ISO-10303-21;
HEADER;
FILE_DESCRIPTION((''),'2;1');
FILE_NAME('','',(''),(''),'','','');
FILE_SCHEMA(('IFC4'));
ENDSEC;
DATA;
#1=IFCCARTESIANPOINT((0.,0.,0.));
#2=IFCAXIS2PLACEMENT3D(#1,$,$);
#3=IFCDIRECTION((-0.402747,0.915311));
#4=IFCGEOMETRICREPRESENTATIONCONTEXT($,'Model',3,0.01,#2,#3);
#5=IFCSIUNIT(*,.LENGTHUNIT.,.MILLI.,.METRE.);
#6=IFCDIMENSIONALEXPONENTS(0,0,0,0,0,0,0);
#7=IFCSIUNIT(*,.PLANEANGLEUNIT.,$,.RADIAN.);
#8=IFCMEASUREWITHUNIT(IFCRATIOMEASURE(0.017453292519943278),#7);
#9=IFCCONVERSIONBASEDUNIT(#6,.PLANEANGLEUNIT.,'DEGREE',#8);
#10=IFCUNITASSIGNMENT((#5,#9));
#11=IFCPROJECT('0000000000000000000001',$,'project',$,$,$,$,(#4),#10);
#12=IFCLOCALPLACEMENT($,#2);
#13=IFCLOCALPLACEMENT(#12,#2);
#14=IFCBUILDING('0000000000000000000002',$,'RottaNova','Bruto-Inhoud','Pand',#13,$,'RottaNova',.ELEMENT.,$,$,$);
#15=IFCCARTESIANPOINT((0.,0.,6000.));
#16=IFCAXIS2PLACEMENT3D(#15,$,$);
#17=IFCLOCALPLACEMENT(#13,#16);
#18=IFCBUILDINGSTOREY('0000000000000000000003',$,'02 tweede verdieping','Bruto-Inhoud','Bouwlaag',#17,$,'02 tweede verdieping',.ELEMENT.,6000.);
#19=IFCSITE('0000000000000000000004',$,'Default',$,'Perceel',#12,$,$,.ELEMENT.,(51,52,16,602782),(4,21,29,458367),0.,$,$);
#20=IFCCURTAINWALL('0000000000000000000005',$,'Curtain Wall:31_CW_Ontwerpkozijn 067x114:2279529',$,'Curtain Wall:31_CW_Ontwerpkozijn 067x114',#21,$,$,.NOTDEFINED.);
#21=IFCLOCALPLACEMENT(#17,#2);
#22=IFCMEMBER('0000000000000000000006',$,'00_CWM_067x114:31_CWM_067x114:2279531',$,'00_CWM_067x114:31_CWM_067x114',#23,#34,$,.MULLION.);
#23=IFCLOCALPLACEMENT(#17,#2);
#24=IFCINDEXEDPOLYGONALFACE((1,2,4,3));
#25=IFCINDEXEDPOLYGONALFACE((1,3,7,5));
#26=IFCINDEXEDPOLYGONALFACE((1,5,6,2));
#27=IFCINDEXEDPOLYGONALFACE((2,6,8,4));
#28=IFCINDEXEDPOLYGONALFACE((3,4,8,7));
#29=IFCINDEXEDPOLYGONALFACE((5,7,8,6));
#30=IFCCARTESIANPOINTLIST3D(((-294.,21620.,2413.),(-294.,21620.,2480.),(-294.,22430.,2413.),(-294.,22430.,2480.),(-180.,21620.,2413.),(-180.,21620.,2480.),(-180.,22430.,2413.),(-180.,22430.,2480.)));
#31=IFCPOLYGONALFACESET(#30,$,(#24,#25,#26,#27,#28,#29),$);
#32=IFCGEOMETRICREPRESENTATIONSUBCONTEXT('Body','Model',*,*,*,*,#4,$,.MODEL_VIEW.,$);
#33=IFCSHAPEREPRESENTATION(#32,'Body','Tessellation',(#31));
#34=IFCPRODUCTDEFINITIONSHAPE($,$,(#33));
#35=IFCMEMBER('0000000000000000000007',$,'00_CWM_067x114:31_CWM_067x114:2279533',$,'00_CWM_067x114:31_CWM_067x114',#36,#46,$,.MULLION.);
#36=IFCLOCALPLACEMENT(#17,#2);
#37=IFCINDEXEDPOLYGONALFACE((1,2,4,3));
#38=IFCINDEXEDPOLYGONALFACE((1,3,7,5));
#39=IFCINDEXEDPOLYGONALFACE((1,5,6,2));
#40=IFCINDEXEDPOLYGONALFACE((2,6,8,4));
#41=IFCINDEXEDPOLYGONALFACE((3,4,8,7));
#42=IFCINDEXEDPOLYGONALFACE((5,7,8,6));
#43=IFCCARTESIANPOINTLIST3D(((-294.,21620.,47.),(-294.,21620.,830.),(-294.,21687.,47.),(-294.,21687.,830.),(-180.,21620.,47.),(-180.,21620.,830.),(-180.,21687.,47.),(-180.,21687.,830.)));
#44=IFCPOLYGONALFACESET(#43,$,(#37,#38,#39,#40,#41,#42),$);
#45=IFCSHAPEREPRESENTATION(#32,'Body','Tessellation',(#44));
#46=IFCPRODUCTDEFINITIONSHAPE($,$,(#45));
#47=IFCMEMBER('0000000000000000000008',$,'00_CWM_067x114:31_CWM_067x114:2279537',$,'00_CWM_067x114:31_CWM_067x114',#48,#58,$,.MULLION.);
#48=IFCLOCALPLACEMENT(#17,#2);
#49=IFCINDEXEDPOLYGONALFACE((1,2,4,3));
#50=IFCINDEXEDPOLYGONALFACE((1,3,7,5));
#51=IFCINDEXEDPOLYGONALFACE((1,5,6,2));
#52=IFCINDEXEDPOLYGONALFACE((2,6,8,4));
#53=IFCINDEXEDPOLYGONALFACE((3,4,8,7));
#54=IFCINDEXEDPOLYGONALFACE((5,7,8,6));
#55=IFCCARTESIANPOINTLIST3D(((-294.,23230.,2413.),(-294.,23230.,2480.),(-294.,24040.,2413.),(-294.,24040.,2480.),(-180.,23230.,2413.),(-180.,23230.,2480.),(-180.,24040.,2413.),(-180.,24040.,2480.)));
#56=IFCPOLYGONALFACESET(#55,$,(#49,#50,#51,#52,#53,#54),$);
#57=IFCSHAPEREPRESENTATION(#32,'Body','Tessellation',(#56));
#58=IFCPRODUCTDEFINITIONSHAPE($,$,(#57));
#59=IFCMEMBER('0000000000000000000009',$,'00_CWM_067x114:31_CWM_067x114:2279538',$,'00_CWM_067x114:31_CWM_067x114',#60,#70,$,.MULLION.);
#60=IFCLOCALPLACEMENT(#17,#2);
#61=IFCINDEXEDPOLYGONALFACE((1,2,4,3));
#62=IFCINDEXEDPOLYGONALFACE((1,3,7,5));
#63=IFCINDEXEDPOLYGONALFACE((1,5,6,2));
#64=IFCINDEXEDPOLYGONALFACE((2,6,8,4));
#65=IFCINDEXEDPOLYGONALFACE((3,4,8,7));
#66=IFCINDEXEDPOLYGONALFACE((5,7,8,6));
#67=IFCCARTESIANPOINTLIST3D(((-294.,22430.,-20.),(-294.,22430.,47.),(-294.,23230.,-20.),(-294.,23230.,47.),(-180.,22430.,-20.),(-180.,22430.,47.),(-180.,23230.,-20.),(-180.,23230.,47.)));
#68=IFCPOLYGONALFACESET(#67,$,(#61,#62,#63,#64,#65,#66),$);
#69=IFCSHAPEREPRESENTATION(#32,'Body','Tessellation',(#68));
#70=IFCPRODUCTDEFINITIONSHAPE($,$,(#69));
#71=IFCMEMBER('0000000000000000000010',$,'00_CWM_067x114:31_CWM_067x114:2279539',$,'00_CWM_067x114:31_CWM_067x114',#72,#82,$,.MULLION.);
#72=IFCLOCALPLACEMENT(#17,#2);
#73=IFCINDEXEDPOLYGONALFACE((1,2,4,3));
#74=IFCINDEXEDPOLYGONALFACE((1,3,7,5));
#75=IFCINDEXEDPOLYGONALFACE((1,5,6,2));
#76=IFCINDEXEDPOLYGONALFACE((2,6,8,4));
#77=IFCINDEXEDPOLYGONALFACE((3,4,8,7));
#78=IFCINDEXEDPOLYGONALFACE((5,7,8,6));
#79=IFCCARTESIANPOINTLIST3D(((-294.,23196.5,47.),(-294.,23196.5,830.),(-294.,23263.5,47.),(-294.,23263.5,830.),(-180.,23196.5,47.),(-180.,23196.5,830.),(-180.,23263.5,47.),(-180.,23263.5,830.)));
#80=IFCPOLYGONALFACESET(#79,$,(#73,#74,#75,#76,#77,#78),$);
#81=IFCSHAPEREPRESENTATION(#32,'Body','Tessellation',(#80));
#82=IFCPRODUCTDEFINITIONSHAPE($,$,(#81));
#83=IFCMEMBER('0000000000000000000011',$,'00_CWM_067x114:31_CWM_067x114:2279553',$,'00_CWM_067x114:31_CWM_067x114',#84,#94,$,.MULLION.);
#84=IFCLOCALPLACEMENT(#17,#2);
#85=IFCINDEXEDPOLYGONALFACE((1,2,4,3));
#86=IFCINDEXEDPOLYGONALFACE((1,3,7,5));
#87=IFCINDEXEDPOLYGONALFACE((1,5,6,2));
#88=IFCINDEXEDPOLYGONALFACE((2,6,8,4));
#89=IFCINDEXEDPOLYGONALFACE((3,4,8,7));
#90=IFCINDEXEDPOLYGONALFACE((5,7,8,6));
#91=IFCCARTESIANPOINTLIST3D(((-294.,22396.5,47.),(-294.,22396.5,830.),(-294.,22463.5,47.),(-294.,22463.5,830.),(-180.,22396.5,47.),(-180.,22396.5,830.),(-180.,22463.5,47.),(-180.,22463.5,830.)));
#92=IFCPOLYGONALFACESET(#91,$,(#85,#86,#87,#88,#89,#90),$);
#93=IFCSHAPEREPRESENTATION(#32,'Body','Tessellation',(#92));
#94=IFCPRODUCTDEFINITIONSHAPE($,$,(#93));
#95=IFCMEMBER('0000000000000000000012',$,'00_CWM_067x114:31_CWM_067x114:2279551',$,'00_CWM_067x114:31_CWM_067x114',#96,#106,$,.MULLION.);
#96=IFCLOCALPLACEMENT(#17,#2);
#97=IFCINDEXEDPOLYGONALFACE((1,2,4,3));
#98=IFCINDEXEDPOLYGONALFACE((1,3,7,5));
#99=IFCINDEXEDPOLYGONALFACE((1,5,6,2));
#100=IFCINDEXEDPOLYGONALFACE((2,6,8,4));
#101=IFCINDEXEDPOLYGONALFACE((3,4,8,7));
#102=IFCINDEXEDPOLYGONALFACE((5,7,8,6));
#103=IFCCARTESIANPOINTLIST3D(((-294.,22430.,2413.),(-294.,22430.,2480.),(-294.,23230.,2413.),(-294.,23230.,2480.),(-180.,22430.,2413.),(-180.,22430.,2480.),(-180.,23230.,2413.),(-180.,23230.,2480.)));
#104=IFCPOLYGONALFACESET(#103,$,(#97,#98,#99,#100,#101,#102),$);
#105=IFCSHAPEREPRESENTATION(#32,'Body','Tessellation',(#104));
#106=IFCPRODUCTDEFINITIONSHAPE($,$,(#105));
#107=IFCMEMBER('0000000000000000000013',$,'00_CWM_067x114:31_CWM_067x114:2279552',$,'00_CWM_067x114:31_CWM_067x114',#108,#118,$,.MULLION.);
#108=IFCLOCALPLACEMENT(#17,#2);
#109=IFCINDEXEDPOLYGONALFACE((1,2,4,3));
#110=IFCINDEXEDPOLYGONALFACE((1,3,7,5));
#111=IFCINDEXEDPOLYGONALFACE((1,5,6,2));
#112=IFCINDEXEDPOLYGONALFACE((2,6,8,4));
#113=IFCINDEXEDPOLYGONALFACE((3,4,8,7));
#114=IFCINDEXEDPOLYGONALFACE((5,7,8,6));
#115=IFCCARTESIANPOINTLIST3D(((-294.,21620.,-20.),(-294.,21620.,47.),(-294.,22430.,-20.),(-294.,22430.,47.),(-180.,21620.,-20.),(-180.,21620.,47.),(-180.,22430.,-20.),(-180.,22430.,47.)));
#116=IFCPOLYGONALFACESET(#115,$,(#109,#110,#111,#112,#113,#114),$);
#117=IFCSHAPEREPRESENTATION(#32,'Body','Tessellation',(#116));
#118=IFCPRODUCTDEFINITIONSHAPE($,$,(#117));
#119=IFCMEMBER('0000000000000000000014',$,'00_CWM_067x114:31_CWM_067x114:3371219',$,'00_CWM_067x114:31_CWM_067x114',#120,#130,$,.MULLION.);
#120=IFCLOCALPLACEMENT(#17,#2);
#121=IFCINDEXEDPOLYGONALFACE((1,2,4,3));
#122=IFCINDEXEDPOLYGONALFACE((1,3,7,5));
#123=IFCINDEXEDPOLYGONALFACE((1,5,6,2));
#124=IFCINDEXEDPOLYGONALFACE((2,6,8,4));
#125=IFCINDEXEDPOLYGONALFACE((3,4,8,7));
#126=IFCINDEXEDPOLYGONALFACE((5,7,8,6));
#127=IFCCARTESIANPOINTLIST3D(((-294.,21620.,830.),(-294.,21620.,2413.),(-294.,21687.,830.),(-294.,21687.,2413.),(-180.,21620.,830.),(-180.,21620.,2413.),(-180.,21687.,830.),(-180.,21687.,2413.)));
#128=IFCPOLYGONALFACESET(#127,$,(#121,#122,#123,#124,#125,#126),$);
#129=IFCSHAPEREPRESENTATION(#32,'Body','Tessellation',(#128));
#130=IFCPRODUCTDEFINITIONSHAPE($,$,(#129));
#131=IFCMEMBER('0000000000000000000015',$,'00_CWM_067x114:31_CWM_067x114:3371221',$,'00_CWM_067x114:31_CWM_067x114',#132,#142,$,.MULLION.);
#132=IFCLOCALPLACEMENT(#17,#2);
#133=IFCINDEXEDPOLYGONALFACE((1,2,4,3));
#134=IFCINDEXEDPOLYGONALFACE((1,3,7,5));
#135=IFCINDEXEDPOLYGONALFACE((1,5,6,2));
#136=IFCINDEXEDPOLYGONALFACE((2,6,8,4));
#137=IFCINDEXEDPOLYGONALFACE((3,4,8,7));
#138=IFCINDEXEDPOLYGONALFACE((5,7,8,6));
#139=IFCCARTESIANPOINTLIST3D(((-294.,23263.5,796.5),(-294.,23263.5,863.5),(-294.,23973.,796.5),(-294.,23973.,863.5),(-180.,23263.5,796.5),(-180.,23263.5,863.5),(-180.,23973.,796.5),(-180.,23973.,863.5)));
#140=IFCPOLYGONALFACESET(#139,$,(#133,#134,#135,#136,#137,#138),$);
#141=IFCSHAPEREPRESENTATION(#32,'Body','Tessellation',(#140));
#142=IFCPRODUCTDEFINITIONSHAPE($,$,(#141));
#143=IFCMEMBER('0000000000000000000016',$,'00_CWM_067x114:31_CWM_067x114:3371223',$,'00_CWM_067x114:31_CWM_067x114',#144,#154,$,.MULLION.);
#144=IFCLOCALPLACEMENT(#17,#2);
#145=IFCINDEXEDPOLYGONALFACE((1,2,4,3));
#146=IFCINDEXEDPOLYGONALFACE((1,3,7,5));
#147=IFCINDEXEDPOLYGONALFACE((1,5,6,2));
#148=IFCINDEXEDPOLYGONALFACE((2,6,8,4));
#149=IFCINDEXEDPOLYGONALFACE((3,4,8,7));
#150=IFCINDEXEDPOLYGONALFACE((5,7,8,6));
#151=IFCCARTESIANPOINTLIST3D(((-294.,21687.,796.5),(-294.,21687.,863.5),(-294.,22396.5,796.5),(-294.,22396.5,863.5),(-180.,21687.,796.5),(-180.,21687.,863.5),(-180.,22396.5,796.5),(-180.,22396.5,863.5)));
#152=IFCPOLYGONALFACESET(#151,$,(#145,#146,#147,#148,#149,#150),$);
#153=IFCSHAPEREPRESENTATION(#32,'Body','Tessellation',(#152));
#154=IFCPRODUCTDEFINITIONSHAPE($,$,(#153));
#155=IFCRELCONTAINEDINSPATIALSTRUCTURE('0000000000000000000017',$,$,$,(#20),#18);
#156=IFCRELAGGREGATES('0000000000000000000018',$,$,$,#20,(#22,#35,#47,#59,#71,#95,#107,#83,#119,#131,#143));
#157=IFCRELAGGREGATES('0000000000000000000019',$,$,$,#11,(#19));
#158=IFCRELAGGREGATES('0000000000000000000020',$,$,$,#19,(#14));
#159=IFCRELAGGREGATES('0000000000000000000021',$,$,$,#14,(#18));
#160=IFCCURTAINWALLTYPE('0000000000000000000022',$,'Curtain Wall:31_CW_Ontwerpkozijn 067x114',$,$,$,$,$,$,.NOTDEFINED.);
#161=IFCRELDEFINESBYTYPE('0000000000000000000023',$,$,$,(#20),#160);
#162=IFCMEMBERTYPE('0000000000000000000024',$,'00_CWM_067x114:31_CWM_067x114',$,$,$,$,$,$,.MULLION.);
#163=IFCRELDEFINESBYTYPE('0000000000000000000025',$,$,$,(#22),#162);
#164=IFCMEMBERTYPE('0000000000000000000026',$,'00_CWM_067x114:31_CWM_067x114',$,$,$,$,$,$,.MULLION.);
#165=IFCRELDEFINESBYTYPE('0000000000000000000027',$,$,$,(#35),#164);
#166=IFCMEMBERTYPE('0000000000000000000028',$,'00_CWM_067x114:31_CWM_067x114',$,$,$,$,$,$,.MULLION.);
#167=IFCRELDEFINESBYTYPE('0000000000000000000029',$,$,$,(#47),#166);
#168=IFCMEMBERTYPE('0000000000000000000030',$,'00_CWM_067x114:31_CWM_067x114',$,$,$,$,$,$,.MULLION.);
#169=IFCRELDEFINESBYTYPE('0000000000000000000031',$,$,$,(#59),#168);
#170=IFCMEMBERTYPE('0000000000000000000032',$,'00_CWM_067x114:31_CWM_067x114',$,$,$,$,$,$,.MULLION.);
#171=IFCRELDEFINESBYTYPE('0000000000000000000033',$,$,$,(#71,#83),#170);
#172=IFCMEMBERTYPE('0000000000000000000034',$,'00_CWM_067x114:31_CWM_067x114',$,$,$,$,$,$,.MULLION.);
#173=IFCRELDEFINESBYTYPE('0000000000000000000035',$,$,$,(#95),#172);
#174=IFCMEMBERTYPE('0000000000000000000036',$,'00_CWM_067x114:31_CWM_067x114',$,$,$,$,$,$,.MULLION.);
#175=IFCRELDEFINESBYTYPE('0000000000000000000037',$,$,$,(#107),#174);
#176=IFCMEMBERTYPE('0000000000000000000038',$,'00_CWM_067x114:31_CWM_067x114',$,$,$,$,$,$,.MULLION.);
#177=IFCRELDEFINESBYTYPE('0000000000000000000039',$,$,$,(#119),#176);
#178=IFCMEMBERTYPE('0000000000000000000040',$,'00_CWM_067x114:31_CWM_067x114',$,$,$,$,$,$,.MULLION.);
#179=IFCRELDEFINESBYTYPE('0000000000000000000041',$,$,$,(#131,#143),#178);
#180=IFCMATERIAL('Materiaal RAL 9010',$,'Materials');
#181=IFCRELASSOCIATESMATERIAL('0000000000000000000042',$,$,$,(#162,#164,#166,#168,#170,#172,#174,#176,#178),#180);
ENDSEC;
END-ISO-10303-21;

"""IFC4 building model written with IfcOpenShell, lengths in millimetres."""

from ifc_helpers import new_model, entity, si_unit, converted_unit, direction, frame, origin, origin_2d_with_axis, place, context, subcontext, project, spatial, rectangle, extrude, source, transform, mapped, material, material_profile, profile_set, type_object, type_shapes, element, aggregate, save


model = new_model("IFC4")

# Units and contexts
model_context = context("Model", 3, precision=0.01, world=origin(), true_north=direction((-0.402747, 0.915311)))
body_context = subcontext(model_context, "Body", "Model", "MODEL_VIEW")
ifc_project = project(units=[si_unit("LENGTHUNIT", "METRE", prefix="MILLI"), converted_unit("PLANEANGLEUNIT", "DEGREE", entity("IfcRatioMeasure", 0.017453292519943278), si_unit("PLANEANGLEUNIT", "RADIAN"), dimensions=[0, 0, 0, 0, 0, 0, 0])], contexts=[model_context])

# Site, building, storey
site_placement = place(None, origin())
site = spatial("IfcSite", under=ifc_project, at=site_placement, Name="Default", ObjectType="Perceel", CompositionType="ELEMENT", RefLatitude=(51, 52, 16, 602782), RefLongitude=(4, 21, 29, 458367), RefElevation=0.0)
building_placement = place(site_placement, origin())
building = spatial("IfcBuilding", under=site, at=building_placement, Name="RottaNova", Description="Bruto-Inhoud", ObjectType="Pand", LongName="RottaNova", CompositionType="ELEMENT")
storey_placement = place(building_placement, frame((0.0, 0.0, 6000.0)))
storey = spatial("IfcBuildingStorey", under=building, at=storey_placement, Name="02 tweede verdieping", Description="Bruto-Inhoud", ObjectType="Bouwlaag", LongName="02 tweede verdieping", CompositionType="ELEMENT", Elevation=6000.0)

# Curtain wall, members
curtain_wall_type = type_object("IfcCurtainWallType", Name="Curtain Wall:31_CW_Ontwerpkozijn 067x114", PredefinedType="NOTDEFINED")
curtain_wall_1_placement = place(storey_placement, frame((0.0, 0.0, -6000.0)))
curtain_wall_1 = element("IfcCurtainWall", 1, at=curtain_wall_1_placement, inside=storey, type_object=curtain_wall_type, Name="Curtain Wall:31_CW_Ontwerpkozijn 067x114:2279529", ObjectType="Curtain Wall:31_CW_Ontwerpkozijn 067x114", PredefinedType="NOTDEFINED")
ifc_material_1 = material(Name="Materiaal RAL 9010", Category="Materials")
ifc_material_profile = material_profile(ifc_material_1, rectangle(XDim=114.0, YDim=67.0, at=origin_2d_with_axis()), Name="31_CWM_067x114")
ifc_profile_set = profile_set([ifc_material_profile], Name="31_CWM_067x114")
member_type_1 = type_object("IfcMemberType", Name="00_CWM_067x114:31_CWM_067x114", PredefinedType="MULLION", material=ifc_profile_set)
shared_shape_1 = source(origin(), body_context, "Body", "SweptSolid", [
    extrude(rectangle(XDim=114.0, YDim=67.0, at=origin_2d_with_axis()), frame((-33.5, 57.0, -810.0), z_axis=(0.0, 0.0, 1.0), x_axis=(0.0, -1.0, 0.0)), (0.0, 0.0, 1.0), 810.0),
])
type_shapes(member_type_1, [shared_shape_1])
member_1_placement = place(curtain_wall_1_placement, frame((-180.0, 21620.0, 8480.0), z_axis=(0.0, -1.0, 0.0), x_axis=(0.0, 0.0, 1.0)))
member_1 = element("IfcMember", 2, at=member_1_placement, type_object=member_type_1, Name="00_CWM_067x114:31_CWM_067x114:2279531", ObjectType="00_CWM_067x114:31_CWM_067x114", PredefinedType="MULLION", context=body_context, shape_type="MappedRepresentation", body=[
    mapped(shared_shape_1, transform((0.0, 0.0, 0.0), scale=1.0)),
])
member_type_2 = type_object("IfcMemberType", Name="00_CWM_067x114:31_CWM_067x114", PredefinedType="MULLION", material=ifc_profile_set)
shared_shape_2 = source(origin(), body_context, "Body", "SweptSolid", [
    extrude(rectangle(XDim=114.0, YDim=67.0, at=origin_2d_with_axis()), frame((-33.5, 57.0, -783.0), z_axis=(0.0, 0.0, 1.0), x_axis=(0.0, -1.0, 0.0)), (0.0, 0.0, 1.0), 783.0),
])
type_shapes(member_type_2, [shared_shape_2])
member_2_placement = place(curtain_wall_1_placement, frame((-180.0, 21620.0, 6047.0), z_axis=(0.0, 0.0, -1.0), x_axis=(0.0, -1.0, 0.0)))
member_2 = element("IfcMember", 3, at=member_2_placement, type_object=member_type_2, Name="00_CWM_067x114:31_CWM_067x114:2279533", ObjectType="00_CWM_067x114:31_CWM_067x114", PredefinedType="MULLION", context=body_context, shape_type="MappedRepresentation", body=[
    mapped(shared_shape_2, transform((0.0, 0.0, 0.0), scale=1.0)),
])
member_type_3 = type_object("IfcMemberType", Name="00_CWM_067x114:31_CWM_067x114", PredefinedType="MULLION", material=ifc_profile_set)
shared_shape_3 = source(origin(), body_context, "Body", "SweptSolid", [
    extrude(rectangle(XDim=114.0, YDim=67.0, at=origin_2d_with_axis()), frame((-33.5, 57.0, -810.0), z_axis=(0.0, 0.0, 1.0), x_axis=(0.0, -1.0, 0.0)), (0.0, 0.0, 1.0), 810.0),
])
type_shapes(member_type_3, [shared_shape_3])
member_3_placement = place(curtain_wall_1_placement, frame((-180.0, 23230.0, 8480.0), z_axis=(0.0, -1.0, 0.0), x_axis=(0.0, 0.0, 1.0)))
member_3 = element("IfcMember", 4, at=member_3_placement, type_object=member_type_3, Name="00_CWM_067x114:31_CWM_067x114:2279537", ObjectType="00_CWM_067x114:31_CWM_067x114", PredefinedType="MULLION", context=body_context, shape_type="MappedRepresentation", body=[
    mapped(shared_shape_3, transform((0.0, 0.0, 0.0), scale=1.0)),
])
member_type_4 = type_object("IfcMemberType", Name="00_CWM_067x114:31_CWM_067x114", PredefinedType="MULLION", material=ifc_profile_set)
shared_shape_4 = source(origin(), body_context, "Body", "SweptSolid", [
    extrude(rectangle(XDim=114.0, YDim=67.0, at=origin_2d_with_axis()), frame((-33.5, 57.0, -800.0), z_axis=(0.0, 0.0, 1.0), x_axis=(0.0, -1.0, 0.0)), (0.0, 0.0, 1.0), 800.0),
])
type_shapes(member_type_4, [shared_shape_4])
member_4_placement = place(curtain_wall_1_placement, frame((-180.0, 23230.0, 5980.0), z_axis=(0.0, 1.0, 0.0), x_axis=(0.0, 0.0, -1.0)))
member_4 = element("IfcMember", 5, at=member_4_placement, type_object=member_type_4, Name="00_CWM_067x114:31_CWM_067x114:2279538", ObjectType="00_CWM_067x114:31_CWM_067x114", PredefinedType="MULLION", context=body_context, shape_type="MappedRepresentation", body=[
    mapped(shared_shape_4, transform((0.0, 0.0, 0.0), scale=1.0)),
])
member_type_5 = type_object("IfcMemberType", Name="00_CWM_067x114:31_CWM_067x114", PredefinedType="MULLION", material=ifc_profile_set)
shared_shape_5 = source(origin(), body_context, "Body", "SweptSolid", [
    extrude(rectangle(XDim=114.0, YDim=67.0, at=origin_2d_with_axis()), frame((0.0, 57.0, -783.0), z_axis=(0.0, 0.0, 1.0), x_axis=(0.0, -1.0, 0.0)), (0.0, 0.0, 1.0), 783.0),
])
type_shapes(member_type_5, [shared_shape_5])
member_5_placement = place(curtain_wall_1_placement, frame((-180.0, 23230.0, 6047.0), z_axis=(0.0, 0.0, -1.0), x_axis=(0.0, -1.0, 0.0)))
member_5 = element("IfcMember", 6, at=member_5_placement, type_object=member_type_5, Name="00_CWM_067x114:31_CWM_067x114:2279539", ObjectType="00_CWM_067x114:31_CWM_067x114", PredefinedType="MULLION", context=body_context, shape_type="MappedRepresentation", body=[
    mapped(shared_shape_5, transform((0.0, 0.0, 0.0), scale=1.0)),
])
member_6_placement = place(curtain_wall_1_placement, frame((-180.0, 22430.0, 6047.0), z_axis=(0.0, 0.0, -1.0), x_axis=(0.0, -1.0, 0.0)))
member_6 = element("IfcMember", 7, at=member_6_placement, type_object=member_type_5, Name="00_CWM_067x114:31_CWM_067x114:2279553", ObjectType="00_CWM_067x114:31_CWM_067x114", PredefinedType="MULLION", context=body_context, shape_type="MappedRepresentation", body=[
    mapped(shared_shape_5, transform((0.0, 0.0, 0.0), scale=1.0)),
])
member_type_6 = type_object("IfcMemberType", Name="00_CWM_067x114:31_CWM_067x114", PredefinedType="MULLION", material=ifc_profile_set)
shared_shape_6 = source(origin(), body_context, "Body", "SweptSolid", [
    extrude(rectangle(XDim=114.0, YDim=67.0, at=origin_2d_with_axis()), frame((-33.5, 57.0, -800.0), z_axis=(0.0, 0.0, 1.0), x_axis=(0.0, -1.0, 0.0)), (0.0, 0.0, 1.0), 800.0),
])
type_shapes(member_type_6, [shared_shape_6])
member_7_placement = place(curtain_wall_1_placement, frame((-180.0, 22430.0, 8480.0), z_axis=(0.0, -1.0, 0.0), x_axis=(0.0, 0.0, 1.0)))
member_7 = element("IfcMember", 8, at=member_7_placement, type_object=member_type_6, Name="00_CWM_067x114:31_CWM_067x114:2279551", ObjectType="00_CWM_067x114:31_CWM_067x114", PredefinedType="MULLION", context=body_context, shape_type="MappedRepresentation", body=[
    mapped(shared_shape_6, transform((0.0, 0.0, 0.0), scale=1.0)),
])
member_type_7 = type_object("IfcMemberType", Name="00_CWM_067x114:31_CWM_067x114", PredefinedType="MULLION", material=ifc_profile_set)
shared_shape_7 = source(origin(), body_context, "Body", "SweptSolid", [
    extrude(rectangle(XDim=114.0, YDim=67.0, at=origin_2d_with_axis()), frame((-33.5, 57.0, -810.0), z_axis=(0.0, 0.0, 1.0), x_axis=(0.0, -1.0, 0.0)), (0.0, 0.0, 1.0), 810.0),
])
type_shapes(member_type_7, [shared_shape_7])
member_8_placement = place(curtain_wall_1_placement, frame((-180.0, 22430.0, 5980.0), z_axis=(0.0, 1.0, 0.0), x_axis=(0.0, 0.0, -1.0)))
member_8 = element("IfcMember", 9, at=member_8_placement, type_object=member_type_7, Name="00_CWM_067x114:31_CWM_067x114:2279552", ObjectType="00_CWM_067x114:31_CWM_067x114", PredefinedType="MULLION", context=body_context, shape_type="MappedRepresentation", body=[
    mapped(shared_shape_7, transform((0.0, 0.0, 0.0), scale=1.0)),
])
member_type_8 = type_object("IfcMemberType", Name="00_CWM_067x114:31_CWM_067x114", PredefinedType="MULLION", material=ifc_profile_set)
shared_shape_8 = source(origin(), body_context, "Body", "SweptSolid", [
    extrude(rectangle(XDim=114.0, YDim=67.0, at=origin_2d_with_axis()), frame((-33.5, 57.0, -1583.0), z_axis=(0.0, 0.0, 1.0), x_axis=(0.0, -1.0, 0.0)), (0.0, 0.0, 1.0), 1583.0),
])
type_shapes(member_type_8, [shared_shape_8])
member_9_placement = place(curtain_wall_1_placement, frame((-180.0, 21620.0, 6830.0), z_axis=(0.0, 0.0, -1.0), x_axis=(0.0, -1.0, 0.0)))
member_9 = element("IfcMember", 10, at=member_9_placement, type_object=member_type_8, Name="00_CWM_067x114:31_CWM_067x114:3371219", ObjectType="00_CWM_067x114:31_CWM_067x114", PredefinedType="MULLION", context=body_context, shape_type="MappedRepresentation", body=[
    mapped(shared_shape_8, transform((0.0, 0.0, 0.0), scale=1.0)),
])
member_type_9 = type_object("IfcMemberType", Name="00_CWM_067x114:31_CWM_067x114", PredefinedType="MULLION", material=ifc_profile_set)
shared_shape_9 = source(origin(), body_context, "Body", "SweptSolid", [
    extrude(rectangle(XDim=114.0, YDim=67.0, at=origin_2d_with_axis()), frame((0.0, 57.0, -709.5), z_axis=(0.0, 0.0, 1.0), x_axis=(0.0, -1.0, 0.0)), (0.0, 0.0, 1.0), 709.5),
])
type_shapes(member_type_9, [shared_shape_9])
member_10_placement = place(curtain_wall_1_placement, frame((-180.0, 23263.5, 6830.0), z_axis=(0.0, -1.0, 0.0), x_axis=(0.0, 0.0, 1.0)))
member_10 = element("IfcMember", 11, at=member_10_placement, type_object=member_type_9, Name="00_CWM_067x114:31_CWM_067x114:3371221", ObjectType="00_CWM_067x114:31_CWM_067x114", PredefinedType="MULLION", context=body_context, shape_type="MappedRepresentation", body=[
    mapped(shared_shape_9, transform((0.0, 0.0, 0.0), scale=1.0)),
])
member_11_placement = place(curtain_wall_1_placement, frame((-180.0, 21687.0, 6830.0), z_axis=(0.0, -1.0, 0.0), x_axis=(0.0, 0.0, 1.0)))
member_11 = element("IfcMember", 12, at=member_11_placement, type_object=member_type_9, Name="00_CWM_067x114:31_CWM_067x114:3371223", ObjectType="00_CWM_067x114:31_CWM_067x114", PredefinedType="MULLION", context=body_context, shape_type="MappedRepresentation", body=[
    mapped(shared_shape_9, transform((0.0, 0.0, 0.0), scale=1.0)),
])

aggregate(curtain_wall_1, [member_1, member_2, member_3, member_4, member_5, member_7, member_8, member_6, member_9, member_10, member_11])

save(model, "model.ifc")
